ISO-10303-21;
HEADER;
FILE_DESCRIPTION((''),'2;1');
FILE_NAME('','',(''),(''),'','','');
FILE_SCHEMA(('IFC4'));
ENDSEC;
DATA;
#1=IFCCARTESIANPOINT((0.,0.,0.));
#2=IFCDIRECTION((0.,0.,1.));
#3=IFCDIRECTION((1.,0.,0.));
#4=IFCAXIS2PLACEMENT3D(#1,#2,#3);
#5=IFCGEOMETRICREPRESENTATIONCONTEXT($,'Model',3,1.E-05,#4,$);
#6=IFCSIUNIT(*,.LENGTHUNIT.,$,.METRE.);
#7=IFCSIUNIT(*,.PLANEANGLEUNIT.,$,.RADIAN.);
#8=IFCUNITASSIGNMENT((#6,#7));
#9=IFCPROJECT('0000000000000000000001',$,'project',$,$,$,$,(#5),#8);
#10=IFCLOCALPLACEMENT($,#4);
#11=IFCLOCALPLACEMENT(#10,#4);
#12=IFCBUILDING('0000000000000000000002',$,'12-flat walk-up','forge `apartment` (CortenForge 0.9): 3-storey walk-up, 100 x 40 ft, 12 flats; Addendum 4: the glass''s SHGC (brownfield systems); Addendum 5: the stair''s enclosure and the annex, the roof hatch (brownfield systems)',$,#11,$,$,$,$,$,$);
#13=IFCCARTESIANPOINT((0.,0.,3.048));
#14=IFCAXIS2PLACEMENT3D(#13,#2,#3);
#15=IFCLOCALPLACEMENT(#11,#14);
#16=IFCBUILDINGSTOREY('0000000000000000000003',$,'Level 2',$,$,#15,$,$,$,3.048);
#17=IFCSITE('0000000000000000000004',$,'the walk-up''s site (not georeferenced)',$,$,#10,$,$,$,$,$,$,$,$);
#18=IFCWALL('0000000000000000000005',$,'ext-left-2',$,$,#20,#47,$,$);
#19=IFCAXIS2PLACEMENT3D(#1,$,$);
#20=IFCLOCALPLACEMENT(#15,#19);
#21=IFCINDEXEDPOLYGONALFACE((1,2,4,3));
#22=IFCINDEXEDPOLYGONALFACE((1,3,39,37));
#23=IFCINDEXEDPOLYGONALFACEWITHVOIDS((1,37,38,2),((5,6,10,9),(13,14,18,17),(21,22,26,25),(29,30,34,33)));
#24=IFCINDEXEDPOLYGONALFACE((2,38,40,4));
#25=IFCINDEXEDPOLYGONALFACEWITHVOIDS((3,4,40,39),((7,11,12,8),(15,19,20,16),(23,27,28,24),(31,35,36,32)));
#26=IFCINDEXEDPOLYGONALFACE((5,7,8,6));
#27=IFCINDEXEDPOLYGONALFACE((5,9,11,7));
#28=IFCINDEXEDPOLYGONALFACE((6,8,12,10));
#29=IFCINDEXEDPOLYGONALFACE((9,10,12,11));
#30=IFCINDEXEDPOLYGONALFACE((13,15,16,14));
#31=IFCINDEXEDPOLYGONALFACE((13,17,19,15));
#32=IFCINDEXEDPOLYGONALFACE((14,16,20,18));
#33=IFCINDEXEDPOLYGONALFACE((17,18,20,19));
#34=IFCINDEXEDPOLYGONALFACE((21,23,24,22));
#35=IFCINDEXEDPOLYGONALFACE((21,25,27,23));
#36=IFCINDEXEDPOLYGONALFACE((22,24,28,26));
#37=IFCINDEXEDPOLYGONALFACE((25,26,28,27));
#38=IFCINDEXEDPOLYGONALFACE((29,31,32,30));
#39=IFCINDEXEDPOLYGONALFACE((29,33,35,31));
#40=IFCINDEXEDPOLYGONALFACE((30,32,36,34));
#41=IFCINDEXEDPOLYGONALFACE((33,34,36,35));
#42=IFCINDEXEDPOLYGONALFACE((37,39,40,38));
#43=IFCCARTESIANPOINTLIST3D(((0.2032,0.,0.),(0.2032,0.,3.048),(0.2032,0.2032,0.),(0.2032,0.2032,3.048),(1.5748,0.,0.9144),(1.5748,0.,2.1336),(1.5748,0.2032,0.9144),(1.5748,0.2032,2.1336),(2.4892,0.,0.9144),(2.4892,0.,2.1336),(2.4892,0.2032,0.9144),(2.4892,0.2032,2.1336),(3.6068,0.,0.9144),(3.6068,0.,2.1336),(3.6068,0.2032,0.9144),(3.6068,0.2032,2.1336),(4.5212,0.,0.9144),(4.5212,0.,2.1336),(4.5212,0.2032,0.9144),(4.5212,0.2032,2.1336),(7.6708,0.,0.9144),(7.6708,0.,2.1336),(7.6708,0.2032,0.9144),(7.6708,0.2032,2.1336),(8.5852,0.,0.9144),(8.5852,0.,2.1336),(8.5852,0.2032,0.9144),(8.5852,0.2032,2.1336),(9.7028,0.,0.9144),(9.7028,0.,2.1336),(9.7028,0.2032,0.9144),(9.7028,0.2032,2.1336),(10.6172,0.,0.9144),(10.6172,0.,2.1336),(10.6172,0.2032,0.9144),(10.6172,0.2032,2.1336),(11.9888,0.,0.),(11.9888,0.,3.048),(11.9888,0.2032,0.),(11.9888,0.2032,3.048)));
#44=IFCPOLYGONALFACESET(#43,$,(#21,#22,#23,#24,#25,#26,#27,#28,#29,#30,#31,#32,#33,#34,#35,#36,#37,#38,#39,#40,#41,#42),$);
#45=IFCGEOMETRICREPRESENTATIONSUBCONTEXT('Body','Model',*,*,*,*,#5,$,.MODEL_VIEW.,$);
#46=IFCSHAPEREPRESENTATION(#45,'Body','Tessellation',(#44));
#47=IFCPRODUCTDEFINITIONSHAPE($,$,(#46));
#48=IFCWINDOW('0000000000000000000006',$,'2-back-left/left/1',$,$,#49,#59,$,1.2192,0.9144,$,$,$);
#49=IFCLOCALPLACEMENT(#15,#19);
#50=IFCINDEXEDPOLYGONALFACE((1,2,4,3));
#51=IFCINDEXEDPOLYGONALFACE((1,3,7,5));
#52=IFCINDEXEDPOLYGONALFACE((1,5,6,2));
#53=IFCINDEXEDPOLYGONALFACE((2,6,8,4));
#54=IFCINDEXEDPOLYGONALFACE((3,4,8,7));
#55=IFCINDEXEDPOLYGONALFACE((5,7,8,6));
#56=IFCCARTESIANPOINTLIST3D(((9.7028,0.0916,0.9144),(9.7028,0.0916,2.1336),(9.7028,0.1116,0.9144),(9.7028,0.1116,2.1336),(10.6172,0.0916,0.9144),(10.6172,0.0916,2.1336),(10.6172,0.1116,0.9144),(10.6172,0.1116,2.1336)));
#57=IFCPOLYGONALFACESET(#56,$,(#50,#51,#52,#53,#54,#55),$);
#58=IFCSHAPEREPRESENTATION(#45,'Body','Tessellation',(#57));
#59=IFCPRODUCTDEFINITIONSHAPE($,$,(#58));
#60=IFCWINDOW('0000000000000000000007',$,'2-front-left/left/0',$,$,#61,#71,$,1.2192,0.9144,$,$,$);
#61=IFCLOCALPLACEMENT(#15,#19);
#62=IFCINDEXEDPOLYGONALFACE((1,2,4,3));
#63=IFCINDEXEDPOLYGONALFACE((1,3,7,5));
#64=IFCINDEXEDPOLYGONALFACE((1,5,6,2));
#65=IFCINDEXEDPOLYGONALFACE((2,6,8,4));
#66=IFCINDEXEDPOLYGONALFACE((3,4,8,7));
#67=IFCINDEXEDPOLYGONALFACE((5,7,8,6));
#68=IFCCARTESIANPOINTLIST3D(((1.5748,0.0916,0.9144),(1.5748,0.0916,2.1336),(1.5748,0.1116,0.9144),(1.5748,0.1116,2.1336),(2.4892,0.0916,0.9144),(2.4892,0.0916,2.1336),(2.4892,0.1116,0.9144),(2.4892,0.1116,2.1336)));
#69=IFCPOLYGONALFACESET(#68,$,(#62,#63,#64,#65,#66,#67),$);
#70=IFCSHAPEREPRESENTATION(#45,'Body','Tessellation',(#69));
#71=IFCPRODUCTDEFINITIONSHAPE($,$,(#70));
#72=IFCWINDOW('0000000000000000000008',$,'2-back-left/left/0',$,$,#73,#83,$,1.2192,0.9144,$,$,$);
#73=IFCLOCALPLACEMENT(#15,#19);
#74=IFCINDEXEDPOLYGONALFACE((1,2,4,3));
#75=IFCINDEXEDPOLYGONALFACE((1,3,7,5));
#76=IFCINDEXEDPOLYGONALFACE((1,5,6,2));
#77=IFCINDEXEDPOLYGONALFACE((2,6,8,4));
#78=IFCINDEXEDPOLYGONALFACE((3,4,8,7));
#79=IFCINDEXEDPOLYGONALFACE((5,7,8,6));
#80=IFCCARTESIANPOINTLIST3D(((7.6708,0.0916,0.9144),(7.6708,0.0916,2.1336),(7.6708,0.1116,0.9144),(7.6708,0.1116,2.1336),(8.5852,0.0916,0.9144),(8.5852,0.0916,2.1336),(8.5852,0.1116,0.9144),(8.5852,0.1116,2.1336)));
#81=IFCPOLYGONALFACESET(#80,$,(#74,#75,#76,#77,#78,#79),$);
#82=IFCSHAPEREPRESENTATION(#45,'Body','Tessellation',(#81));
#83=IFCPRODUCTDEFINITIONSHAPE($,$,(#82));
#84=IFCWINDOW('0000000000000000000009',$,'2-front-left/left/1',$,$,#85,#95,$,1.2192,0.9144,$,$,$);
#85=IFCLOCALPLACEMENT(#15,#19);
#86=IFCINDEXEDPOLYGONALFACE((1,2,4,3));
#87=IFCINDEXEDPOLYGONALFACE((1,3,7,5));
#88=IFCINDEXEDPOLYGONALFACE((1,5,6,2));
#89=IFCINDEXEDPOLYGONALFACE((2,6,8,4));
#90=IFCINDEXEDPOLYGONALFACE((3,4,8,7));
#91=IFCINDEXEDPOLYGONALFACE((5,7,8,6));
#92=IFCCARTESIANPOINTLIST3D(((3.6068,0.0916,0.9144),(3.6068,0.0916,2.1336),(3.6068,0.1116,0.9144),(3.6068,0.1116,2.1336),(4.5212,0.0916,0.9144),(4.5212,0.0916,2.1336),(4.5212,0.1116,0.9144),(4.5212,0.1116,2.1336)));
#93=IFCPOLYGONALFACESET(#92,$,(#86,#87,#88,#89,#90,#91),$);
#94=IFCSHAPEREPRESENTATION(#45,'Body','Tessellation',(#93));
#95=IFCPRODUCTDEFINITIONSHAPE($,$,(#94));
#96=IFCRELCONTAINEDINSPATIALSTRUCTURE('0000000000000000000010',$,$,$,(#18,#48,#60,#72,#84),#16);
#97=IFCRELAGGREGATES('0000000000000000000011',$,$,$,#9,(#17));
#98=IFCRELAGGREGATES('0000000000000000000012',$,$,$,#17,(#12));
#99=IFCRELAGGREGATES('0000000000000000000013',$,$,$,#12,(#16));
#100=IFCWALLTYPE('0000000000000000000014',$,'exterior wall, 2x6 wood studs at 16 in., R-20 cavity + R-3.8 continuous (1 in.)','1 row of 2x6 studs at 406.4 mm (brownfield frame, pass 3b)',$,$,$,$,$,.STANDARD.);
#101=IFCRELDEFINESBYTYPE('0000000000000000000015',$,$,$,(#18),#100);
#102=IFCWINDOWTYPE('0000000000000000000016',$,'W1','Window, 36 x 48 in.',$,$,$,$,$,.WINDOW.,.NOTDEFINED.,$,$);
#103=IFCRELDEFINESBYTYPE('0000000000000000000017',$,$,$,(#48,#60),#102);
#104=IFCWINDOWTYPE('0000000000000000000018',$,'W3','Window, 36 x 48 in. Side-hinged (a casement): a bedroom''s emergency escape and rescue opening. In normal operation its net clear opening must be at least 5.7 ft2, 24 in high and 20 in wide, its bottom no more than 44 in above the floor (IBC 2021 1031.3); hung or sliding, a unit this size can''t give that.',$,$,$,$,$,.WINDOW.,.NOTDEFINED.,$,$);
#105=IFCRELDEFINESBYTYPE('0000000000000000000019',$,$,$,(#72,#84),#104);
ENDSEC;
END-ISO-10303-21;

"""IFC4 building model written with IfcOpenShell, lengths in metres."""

from ifc_helpers import new_model, si_unit, frame, frame_2d, origin, origin_with_axes, place, context, subcontext, project, spatial, rectangle, extrude, type_object, element, fill, save


model = new_model("IFC4")

# Units and contexts
model_context = context("Model", 3, precision=1e-05, world=origin_with_axes())
body_context = subcontext(model_context, "Body", "Model", "MODEL_VIEW")
ifc_project = project(units=[si_unit("LENGTHUNIT", "METRE"), si_unit("PLANEANGLEUNIT", "RADIAN")], contexts=[model_context])

# Site, building, storey
site_placement = place(None, origin_with_axes())
site = spatial("IfcSite", under=ifc_project, at=site_placement, Name="the walk-up's site (not georeferenced)")
building_placement = place(site_placement, origin_with_axes())
building = spatial("IfcBuilding", under=site, at=building_placement, Name="12-flat walk-up", Description="forge `apartment` (CortenForge 0.9): 3-storey walk-up, 100 x 40 ft, 12 flats; Addendum 4: the glass's SHGC (brownfield systems); Addendum 5: the stair's enclosure and the annex, the roof hatch (brownfield systems)")
storey_placement = place(building_placement, frame((0.0, 0.0, 3.048), z_axis=(0.0, 0.0, 1.0), x_axis=(1.0, 0.0, 0.0)))
storey = spatial("IfcBuildingStorey", under=building, at=storey_placement, Name="Level 2", Elevation=3.048)

# Shared definitions
wall_type = type_object("IfcWallType", Name="exterior wall, 2x6 wood studs at 16 in., R-20 cavity + R-3.8 continuous (1 in.)", Description="1 row of 2x6 studs at 406.4 mm (brownfield frame, pass 3b)", PredefinedType="STANDARD")
window_type_1 = type_object("IfcWindowType", Name="W1", Description="Window, 36 x 48 in.", PartitioningType="NOTDEFINED", PredefinedType="WINDOW")
window_type_2 = type_object("IfcWindowType", Name="W3", Description="Window, 36 x 48 in. Side-hinged (a casement): a bedroom's emergency escape and rescue opening. In normal operation its net clear opening must be at least 5.7 ft2, 24 in high and 20 in wide, its bottom no more than 44 in above the floor (IBC 2021 1031.3); hung or sliding, a unit this size can't give that.", PartitioningType="NOTDEFINED", PredefinedType="WINDOW")

# Wall, openings, windows
wall_1_placement = place(storey_placement, frame((0.2032, 0.0, 0.0), z_axis=(0.0, 0.0, 1.0), x_axis=(1.0, 0.0, 0.0)))
wall_1 = element("IfcWall", 1, at=wall_1_placement, inside=storey, type_object=wall_type, Name="ext-left-2", context=body_context, shape_type="SweptSolid", body=[
    extrude(rectangle(XDim=11.7856, YDim=0.2032, at=frame_2d((5.8928, 0.1016))), origin(), (0.0, 0.0, 1.0), 3.048),
])
opening_1_placement = place(wall_1_placement, frame((7.4676, 0.0, 0.9144), z_axis=(0.0, 0.0, 1.0), x_axis=(1.0, 0.0, 0.0)))
opening_1 = element("IfcOpeningElement", 2, at=opening_1_placement, cuts=wall_1, PredefinedType="OPENING", context=body_context, shape_type="SweptSolid", body=[
    extrude(rectangle(XDim=0.9144, YDim=0.2032, at=frame_2d((0.4572, 0.1016))), origin(), (0.0, 0.0, 1.0), 1.2192),
])
opening_2_placement = place(wall_1_placement, frame((9.4996, 0.0, 0.9144), z_axis=(0.0, 0.0, 1.0), x_axis=(1.0, 0.0, 0.0)))
opening_2 = element("IfcOpeningElement", 3, at=opening_2_placement, cuts=wall_1, PredefinedType="OPENING", context=body_context, shape_type="SweptSolid", body=[
    extrude(rectangle(XDim=0.9144, YDim=0.2032, at=frame_2d((0.4572, 0.1016))), origin(), (0.0, 0.0, 1.0), 1.2192),
])
opening_3_placement = place(wall_1_placement, frame((1.3716, 0.0, 0.9144), z_axis=(0.0, 0.0, 1.0), x_axis=(1.0, 0.0, 0.0)))
opening_3 = element("IfcOpeningElement", 4, at=opening_3_placement, cuts=wall_1, PredefinedType="OPENING", context=body_context, shape_type="SweptSolid", body=[
    extrude(rectangle(XDim=0.9144, YDim=0.2032, at=frame_2d((0.4572, 0.1016))), origin(), (0.0, 0.0, 1.0), 1.2192),
])
opening_4_placement = place(wall_1_placement, frame((3.4036, 0.0, 0.9144), z_axis=(0.0, 0.0, 1.0), x_axis=(1.0, 0.0, 0.0)))
opening_4 = element("IfcOpeningElement", 5, at=opening_4_placement, cuts=wall_1, PredefinedType="OPENING", context=body_context, shape_type="SweptSolid", body=[
    extrude(rectangle(XDim=0.9144, YDim=0.2032, at=frame_2d((0.4572, 0.1016))), origin(), (0.0, 0.0, 1.0), 1.2192),
])
window_1_placement = place(opening_2_placement, frame((0.0, 0.0916, 0.0), z_axis=(0.0, 0.0, 1.0), x_axis=(1.0, 0.0, 0.0)))
window_1 = element("IfcWindow", 6, at=window_1_placement, inside=storey, type_object=window_type_1, Name="2-back-left/left/1", OverallHeight=1.2192, OverallWidth=0.9144, context=body_context, shape_type="SweptSolid", body=[
    extrude(rectangle(XDim=0.9144, YDim=0.02, at=frame_2d((0.4572, 0.01))), origin(), (0.0, 0.0, 1.0), 1.2192),
])
fill(opening_2, window_1)
window_2_placement = place(opening_3_placement, frame((0.0, 0.0916, 0.0), z_axis=(0.0, 0.0, 1.0), x_axis=(1.0, 0.0, 0.0)))
window_2 = element("IfcWindow", 7, at=window_2_placement, inside=storey, type_object=window_type_1, Name="2-front-left/left/0", OverallHeight=1.2192, OverallWidth=0.9144, context=body_context, shape_type="SweptSolid", body=[
    extrude(rectangle(XDim=0.9144, YDim=0.02, at=frame_2d((0.4572, 0.01))), origin(), (0.0, 0.0, 1.0), 1.2192),
])
fill(opening_3, window_2)
window_3_placement = place(opening_1_placement, frame((0.0, 0.0916, 0.0), z_axis=(0.0, 0.0, 1.0), x_axis=(1.0, 0.0, 0.0)))
window_3 = element("IfcWindow", 8, at=window_3_placement, inside=storey, type_object=window_type_2, Name="2-back-left/left/0", OverallHeight=1.2192, OverallWidth=0.9144, context=body_context, shape_type="SweptSolid", body=[
    extrude(rectangle(XDim=0.9144, YDim=0.02, at=frame_2d((0.4572, 0.01))), origin(), (0.0, 0.0, 1.0), 1.2192),
])
fill(opening_1, window_3)
window_4_placement = place(opening_4_placement, frame((0.0, 0.0916, 0.0), z_axis=(0.0, 0.0, 1.0), x_axis=(1.0, 0.0, 0.0)))
window_4 = element("IfcWindow", 9, at=window_4_placement, inside=storey, type_object=window_type_2, Name="2-front-left/left/1", OverallHeight=1.2192, OverallWidth=0.9144, context=body_context, shape_type="SweptSolid", body=[
    extrude(rectangle(XDim=0.9144, YDim=0.02, at=frame_2d((0.4572, 0.01))), origin(), (0.0, 0.0, 1.0), 1.2192),
])
fill(opening_4, window_4)

save(model, "model.ifc")
